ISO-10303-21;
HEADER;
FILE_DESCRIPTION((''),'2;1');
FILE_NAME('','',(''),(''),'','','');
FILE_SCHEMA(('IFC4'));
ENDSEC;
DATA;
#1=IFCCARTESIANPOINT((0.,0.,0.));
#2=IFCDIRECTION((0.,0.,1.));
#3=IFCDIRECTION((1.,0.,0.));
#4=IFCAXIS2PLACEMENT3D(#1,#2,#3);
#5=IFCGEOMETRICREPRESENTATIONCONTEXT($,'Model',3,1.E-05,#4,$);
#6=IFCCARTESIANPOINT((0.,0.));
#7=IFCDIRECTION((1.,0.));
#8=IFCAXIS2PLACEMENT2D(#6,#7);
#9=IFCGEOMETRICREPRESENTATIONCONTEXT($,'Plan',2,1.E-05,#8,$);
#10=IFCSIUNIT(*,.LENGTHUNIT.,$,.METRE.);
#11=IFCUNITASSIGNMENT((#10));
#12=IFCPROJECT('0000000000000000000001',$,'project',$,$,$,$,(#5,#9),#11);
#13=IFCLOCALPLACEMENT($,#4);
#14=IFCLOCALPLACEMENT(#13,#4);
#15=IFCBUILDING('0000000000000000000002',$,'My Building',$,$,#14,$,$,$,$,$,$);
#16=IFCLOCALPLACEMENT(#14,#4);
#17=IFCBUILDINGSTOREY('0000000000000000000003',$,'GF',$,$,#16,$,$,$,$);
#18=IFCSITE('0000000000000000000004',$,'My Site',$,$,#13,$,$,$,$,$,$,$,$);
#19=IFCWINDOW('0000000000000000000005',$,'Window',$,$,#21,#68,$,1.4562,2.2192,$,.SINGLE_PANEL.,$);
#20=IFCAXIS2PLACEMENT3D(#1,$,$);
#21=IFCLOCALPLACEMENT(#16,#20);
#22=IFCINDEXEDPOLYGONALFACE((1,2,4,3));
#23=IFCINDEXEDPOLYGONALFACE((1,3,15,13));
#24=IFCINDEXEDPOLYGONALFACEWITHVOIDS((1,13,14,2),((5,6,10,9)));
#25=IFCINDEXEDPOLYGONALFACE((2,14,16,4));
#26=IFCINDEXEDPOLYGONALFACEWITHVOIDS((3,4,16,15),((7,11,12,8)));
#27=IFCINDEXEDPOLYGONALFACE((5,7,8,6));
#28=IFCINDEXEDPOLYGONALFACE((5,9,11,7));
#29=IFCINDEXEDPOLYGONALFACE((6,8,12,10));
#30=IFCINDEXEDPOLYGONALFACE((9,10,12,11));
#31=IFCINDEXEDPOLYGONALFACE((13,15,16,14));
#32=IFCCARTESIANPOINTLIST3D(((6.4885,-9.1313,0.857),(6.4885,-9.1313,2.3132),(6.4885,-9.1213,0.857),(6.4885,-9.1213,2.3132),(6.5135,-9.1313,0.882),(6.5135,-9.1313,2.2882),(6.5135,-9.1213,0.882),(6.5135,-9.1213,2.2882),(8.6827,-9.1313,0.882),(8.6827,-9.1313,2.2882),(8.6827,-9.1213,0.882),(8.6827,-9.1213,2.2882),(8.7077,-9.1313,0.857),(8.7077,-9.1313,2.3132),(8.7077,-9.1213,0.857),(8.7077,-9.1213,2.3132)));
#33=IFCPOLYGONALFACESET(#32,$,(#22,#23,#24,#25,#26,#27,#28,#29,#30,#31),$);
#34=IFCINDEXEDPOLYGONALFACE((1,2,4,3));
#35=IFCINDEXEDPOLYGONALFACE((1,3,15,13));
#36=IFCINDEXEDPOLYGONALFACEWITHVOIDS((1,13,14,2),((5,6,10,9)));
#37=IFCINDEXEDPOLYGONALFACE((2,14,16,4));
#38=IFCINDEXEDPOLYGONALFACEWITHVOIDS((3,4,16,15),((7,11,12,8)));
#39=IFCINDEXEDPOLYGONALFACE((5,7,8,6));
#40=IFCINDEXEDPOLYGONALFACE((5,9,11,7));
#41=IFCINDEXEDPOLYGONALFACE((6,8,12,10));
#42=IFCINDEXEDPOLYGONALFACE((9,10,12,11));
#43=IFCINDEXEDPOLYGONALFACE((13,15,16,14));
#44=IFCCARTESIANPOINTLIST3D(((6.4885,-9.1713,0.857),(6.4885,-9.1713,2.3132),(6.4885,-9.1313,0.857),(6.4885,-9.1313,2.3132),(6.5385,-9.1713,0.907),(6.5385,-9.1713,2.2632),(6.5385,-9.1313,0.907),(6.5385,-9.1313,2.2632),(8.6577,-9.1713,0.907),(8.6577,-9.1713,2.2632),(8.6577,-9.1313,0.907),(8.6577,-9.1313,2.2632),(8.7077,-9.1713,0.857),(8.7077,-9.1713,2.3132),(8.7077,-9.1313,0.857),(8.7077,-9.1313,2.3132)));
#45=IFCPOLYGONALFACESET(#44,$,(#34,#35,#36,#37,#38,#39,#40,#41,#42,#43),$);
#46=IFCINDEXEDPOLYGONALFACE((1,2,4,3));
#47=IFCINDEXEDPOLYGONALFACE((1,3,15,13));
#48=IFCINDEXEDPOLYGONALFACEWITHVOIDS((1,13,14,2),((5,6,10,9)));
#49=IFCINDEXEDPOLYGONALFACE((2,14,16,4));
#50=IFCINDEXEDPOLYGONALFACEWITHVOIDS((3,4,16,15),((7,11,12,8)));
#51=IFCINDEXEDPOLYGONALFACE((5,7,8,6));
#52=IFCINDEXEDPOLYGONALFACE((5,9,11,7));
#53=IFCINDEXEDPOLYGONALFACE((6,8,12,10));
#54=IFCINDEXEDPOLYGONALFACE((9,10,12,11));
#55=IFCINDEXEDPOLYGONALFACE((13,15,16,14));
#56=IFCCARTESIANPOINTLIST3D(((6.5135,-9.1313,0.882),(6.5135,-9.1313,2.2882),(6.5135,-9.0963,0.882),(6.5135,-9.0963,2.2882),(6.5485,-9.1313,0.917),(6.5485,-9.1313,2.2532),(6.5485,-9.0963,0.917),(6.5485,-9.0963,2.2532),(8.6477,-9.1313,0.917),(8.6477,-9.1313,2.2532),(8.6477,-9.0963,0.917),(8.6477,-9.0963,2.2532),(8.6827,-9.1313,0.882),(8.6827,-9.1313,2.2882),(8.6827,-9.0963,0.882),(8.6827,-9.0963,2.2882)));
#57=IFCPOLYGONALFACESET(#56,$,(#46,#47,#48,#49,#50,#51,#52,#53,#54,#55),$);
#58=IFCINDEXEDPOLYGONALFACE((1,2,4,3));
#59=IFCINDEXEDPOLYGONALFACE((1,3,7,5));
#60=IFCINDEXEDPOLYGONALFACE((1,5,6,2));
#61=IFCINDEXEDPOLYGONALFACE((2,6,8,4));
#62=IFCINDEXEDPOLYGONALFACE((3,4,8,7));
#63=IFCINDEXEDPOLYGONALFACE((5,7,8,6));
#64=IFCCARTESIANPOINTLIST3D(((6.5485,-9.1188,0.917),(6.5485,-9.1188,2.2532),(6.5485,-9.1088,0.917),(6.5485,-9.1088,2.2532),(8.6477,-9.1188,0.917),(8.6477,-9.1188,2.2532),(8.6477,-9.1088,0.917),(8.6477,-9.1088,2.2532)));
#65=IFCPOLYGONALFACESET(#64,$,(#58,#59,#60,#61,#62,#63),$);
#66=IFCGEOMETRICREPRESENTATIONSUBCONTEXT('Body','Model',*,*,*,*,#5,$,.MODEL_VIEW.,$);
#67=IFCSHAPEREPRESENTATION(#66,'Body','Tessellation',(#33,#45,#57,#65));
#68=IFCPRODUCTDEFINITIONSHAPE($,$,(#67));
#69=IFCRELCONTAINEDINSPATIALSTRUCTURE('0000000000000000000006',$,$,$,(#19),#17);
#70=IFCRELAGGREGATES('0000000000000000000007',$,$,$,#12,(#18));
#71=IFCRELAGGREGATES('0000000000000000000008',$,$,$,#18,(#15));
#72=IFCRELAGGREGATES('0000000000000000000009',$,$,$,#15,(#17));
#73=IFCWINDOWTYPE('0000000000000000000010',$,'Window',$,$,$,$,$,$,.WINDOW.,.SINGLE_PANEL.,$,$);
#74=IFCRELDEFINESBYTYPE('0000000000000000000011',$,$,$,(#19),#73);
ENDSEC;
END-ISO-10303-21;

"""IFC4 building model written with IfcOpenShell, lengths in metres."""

from ifc_helpers import new_model, entity, si_unit, frame, origin_with_axes, origin_2d_with_axis, place, context, subcontext, project, spatial, line, indexed_curve, outline, extrude, shape, source, transform, mapped, type_object, type_shapes, element, save


model = new_model("IFC4")

# Units and contexts
model_context = context("Model", 3, precision=1e-05, world=origin_with_axes())
plan_context = context("Plan", 2, precision=1e-05, world=origin_2d_with_axis())
body_context_1 = subcontext(model_context, "Body", "Model", "MODEL_VIEW")
body_context_2 = subcontext(plan_context, "Body", "Plan", "PLAN_VIEW")
ifc_project = project(units=[si_unit("LENGTHUNIT", "METRE")], contexts=[model_context, plan_context])

# Site, building, storey
site_placement = place(None, origin_with_axes())
site = spatial("IfcSite", under=ifc_project, at=site_placement, Name="My Site")
building_placement = place(site_placement, origin_with_axes())
building = spatial("IfcBuilding", under=site, at=building_placement, Name="My Building")
storey_placement = place(building_placement, origin_with_axes())
storey = spatial("IfcBuildingStorey", under=building, at=storey_placement, Name="GF")

# Shared definitions
window_type_1 = type_object("IfcWindowType", Name="Window", PartitioningType="SINGLE_PANEL", PredefinedType="WINDOW")
shared_shape_1 = source(origin_with_axes(), body_context_1, "Body", "SweptSolid", [
    extrude(outline(indexed_curve([(0.0, 0.0), (2.2192, 0.0), (2.2192, 1.4562), (0.0, 1.4562)], segments=[line(1, 2, 3, 4, 1)]), holes=[indexed_curve([(0.025, 0.025), (2.1942, 0.025), (2.1942, 1.4312), (0.025, 1.4312)], segments=[line(1, 2, 3, 4, 1)])]), frame((0.0, 0.09, 0.0), z_axis=(0.0, -1.0, 0.0), x_axis=(1.0, 0.0, 0.0)), (0.0, 0.0, -1.0), 0.01),
    extrude(outline(indexed_curve([(0.0, 0.0), (2.2192, 0.0), (2.2192, 1.4562), (0.0, 1.4562)], segments=[line(1, 2, 3, 4, 1)]), holes=[indexed_curve([(0.05, 0.05), (2.1692, 0.05), (2.1692, 1.4062), (0.05, 1.4062)], segments=[line(1, 2, 3, 4, 1)])]), frame((0.0, 0.05, 0.0), z_axis=(0.0, -1.0, 0.0), x_axis=(1.0, 0.0, 0.0)), (0.0, 0.0, -1.0), 0.04),
    extrude(outline(indexed_curve([(0.0, 0.0), (2.1692, 0.0), (2.1692, 1.4062), (0.0, 1.4062)], segments=[line(1, 2, 3, 4, 1)]), holes=[indexed_curve([(0.035, 0.035), (2.1342, 0.035), (2.1342, 1.3712), (0.035, 1.3712)], segments=[line(1, 2, 3, 4, 1)])]), frame((0.025, 0.09, 0.025), z_axis=(0.0, -1.0, 0.0), x_axis=(1.0, 0.0, 0.0)), (0.0, 0.0, -1.0), 0.035),
    extrude(outline(indexed_curve([(0.035, 0.035), (2.1342, 0.035), (2.1342, 1.3712), (0.035, 1.3712)], segments=[line(1, 2, 3, 4, 1)])), frame((0.025, 0.1025, 0.025), z_axis=(0.0, -1.0, 0.0), x_axis=(1.0, 0.0, 0.0)), (0.0, 0.0, -1.0), 0.01),
])
shared_shape_2 = source(origin_with_axes(), body_context_2, "Body", "Curve2D", [
    entity("IfcIndexedPolyCurve", entity("IfcCartesianPointList2D", [[0.05, 0.05], [2.1692, 0.05]])),
    entity("IfcIndexedPolyCurve", entity("IfcCartesianPointList2D", [[0.0, 0.1], [0.025, 0.1], [0.025, 0.09], [0.05, 0.09], [0.05, 0.05], [0.0, 0.05]]), [entity("IfcLineIndex", [1, 2, 3, 4, 5, 6, 1])]),
    entity("IfcIndexedPolyCurve", entity("IfcCartesianPointList2D", [[2.2192, 0.1], [2.1942, 0.1], [2.1942, 0.09], [2.1692, 0.09], [2.1692, 0.05], [2.2192, 0.05]]), [entity("IfcLineIndex", [1, 2, 3, 4, 5, 6, 1])]),
    entity("IfcIndexedPolyCurve", entity("IfcCartesianPointList2D", [[0.025, 0.09], [0.06, 0.09], [0.06, 0.125], [0.025, 0.125]]), [entity("IfcLineIndex", [1, 2, 3, 4, 1])]),
    entity("IfcIndexedPolyCurve", entity("IfcCartesianPointList2D", [[2.1942, 0.09], [2.1592, 0.09], [2.1592, 0.125], [2.1942, 0.125]]), [entity("IfcLineIndex", [1, 2, 3, 4, 1])]),
    entity("IfcIndexedPolyCurve", entity("IfcCartesianPointList2D", [[0.06, 0.09], [2.1592, 0.09]])),
    entity("IfcIndexedPolyCurve", entity("IfcCartesianPointList2D", [[0.06, 0.125], [2.1592, 0.125]])),
    entity("IfcIndexedPolyCurve", entity("IfcCartesianPointList2D", [[0.06, 0.1075], [2.1592, 0.1075]])),
])
type_shapes(window_type_1, [shared_shape_1, shared_shape_2])

# Window
window_1_placement = place(storey_placement, frame((6.4885, -9.2213, 0.857), z_axis=(0.0, 0.0, 1.0), x_axis=(1.0, 0.0, 0.0)))
element("IfcWindow", 1, at=window_1_placement, inside=storey, type_object=window_type_1, Name="Window", OverallHeight=1.4562, OverallWidth=2.2192, PartitioningType="SINGLE_PANEL", shapes=[
    shape(body_context_1, "Body", "MappedRepresentation", [mapped(shared_shape_1, transform((0.0, 0.0, 0.0), x_axis=(1.0, 0.0, 0.0), y_axis=(0.0, 1.0, 0.0), z_axis=(0.0, 0.0, 1.0), scale=1.0))]),
    shape(body_context_2, "Body", "MappedRepresentation", [mapped(shared_shape_2, transform((0.0, 0.0, 0.0), x_axis=(1.0, 0.0, 0.0), y_axis=(0.0, 1.0, 0.0), z_axis=(0.0, 0.0, 1.0), scale=1.0))]),
])

save(model, "model.ifc")
